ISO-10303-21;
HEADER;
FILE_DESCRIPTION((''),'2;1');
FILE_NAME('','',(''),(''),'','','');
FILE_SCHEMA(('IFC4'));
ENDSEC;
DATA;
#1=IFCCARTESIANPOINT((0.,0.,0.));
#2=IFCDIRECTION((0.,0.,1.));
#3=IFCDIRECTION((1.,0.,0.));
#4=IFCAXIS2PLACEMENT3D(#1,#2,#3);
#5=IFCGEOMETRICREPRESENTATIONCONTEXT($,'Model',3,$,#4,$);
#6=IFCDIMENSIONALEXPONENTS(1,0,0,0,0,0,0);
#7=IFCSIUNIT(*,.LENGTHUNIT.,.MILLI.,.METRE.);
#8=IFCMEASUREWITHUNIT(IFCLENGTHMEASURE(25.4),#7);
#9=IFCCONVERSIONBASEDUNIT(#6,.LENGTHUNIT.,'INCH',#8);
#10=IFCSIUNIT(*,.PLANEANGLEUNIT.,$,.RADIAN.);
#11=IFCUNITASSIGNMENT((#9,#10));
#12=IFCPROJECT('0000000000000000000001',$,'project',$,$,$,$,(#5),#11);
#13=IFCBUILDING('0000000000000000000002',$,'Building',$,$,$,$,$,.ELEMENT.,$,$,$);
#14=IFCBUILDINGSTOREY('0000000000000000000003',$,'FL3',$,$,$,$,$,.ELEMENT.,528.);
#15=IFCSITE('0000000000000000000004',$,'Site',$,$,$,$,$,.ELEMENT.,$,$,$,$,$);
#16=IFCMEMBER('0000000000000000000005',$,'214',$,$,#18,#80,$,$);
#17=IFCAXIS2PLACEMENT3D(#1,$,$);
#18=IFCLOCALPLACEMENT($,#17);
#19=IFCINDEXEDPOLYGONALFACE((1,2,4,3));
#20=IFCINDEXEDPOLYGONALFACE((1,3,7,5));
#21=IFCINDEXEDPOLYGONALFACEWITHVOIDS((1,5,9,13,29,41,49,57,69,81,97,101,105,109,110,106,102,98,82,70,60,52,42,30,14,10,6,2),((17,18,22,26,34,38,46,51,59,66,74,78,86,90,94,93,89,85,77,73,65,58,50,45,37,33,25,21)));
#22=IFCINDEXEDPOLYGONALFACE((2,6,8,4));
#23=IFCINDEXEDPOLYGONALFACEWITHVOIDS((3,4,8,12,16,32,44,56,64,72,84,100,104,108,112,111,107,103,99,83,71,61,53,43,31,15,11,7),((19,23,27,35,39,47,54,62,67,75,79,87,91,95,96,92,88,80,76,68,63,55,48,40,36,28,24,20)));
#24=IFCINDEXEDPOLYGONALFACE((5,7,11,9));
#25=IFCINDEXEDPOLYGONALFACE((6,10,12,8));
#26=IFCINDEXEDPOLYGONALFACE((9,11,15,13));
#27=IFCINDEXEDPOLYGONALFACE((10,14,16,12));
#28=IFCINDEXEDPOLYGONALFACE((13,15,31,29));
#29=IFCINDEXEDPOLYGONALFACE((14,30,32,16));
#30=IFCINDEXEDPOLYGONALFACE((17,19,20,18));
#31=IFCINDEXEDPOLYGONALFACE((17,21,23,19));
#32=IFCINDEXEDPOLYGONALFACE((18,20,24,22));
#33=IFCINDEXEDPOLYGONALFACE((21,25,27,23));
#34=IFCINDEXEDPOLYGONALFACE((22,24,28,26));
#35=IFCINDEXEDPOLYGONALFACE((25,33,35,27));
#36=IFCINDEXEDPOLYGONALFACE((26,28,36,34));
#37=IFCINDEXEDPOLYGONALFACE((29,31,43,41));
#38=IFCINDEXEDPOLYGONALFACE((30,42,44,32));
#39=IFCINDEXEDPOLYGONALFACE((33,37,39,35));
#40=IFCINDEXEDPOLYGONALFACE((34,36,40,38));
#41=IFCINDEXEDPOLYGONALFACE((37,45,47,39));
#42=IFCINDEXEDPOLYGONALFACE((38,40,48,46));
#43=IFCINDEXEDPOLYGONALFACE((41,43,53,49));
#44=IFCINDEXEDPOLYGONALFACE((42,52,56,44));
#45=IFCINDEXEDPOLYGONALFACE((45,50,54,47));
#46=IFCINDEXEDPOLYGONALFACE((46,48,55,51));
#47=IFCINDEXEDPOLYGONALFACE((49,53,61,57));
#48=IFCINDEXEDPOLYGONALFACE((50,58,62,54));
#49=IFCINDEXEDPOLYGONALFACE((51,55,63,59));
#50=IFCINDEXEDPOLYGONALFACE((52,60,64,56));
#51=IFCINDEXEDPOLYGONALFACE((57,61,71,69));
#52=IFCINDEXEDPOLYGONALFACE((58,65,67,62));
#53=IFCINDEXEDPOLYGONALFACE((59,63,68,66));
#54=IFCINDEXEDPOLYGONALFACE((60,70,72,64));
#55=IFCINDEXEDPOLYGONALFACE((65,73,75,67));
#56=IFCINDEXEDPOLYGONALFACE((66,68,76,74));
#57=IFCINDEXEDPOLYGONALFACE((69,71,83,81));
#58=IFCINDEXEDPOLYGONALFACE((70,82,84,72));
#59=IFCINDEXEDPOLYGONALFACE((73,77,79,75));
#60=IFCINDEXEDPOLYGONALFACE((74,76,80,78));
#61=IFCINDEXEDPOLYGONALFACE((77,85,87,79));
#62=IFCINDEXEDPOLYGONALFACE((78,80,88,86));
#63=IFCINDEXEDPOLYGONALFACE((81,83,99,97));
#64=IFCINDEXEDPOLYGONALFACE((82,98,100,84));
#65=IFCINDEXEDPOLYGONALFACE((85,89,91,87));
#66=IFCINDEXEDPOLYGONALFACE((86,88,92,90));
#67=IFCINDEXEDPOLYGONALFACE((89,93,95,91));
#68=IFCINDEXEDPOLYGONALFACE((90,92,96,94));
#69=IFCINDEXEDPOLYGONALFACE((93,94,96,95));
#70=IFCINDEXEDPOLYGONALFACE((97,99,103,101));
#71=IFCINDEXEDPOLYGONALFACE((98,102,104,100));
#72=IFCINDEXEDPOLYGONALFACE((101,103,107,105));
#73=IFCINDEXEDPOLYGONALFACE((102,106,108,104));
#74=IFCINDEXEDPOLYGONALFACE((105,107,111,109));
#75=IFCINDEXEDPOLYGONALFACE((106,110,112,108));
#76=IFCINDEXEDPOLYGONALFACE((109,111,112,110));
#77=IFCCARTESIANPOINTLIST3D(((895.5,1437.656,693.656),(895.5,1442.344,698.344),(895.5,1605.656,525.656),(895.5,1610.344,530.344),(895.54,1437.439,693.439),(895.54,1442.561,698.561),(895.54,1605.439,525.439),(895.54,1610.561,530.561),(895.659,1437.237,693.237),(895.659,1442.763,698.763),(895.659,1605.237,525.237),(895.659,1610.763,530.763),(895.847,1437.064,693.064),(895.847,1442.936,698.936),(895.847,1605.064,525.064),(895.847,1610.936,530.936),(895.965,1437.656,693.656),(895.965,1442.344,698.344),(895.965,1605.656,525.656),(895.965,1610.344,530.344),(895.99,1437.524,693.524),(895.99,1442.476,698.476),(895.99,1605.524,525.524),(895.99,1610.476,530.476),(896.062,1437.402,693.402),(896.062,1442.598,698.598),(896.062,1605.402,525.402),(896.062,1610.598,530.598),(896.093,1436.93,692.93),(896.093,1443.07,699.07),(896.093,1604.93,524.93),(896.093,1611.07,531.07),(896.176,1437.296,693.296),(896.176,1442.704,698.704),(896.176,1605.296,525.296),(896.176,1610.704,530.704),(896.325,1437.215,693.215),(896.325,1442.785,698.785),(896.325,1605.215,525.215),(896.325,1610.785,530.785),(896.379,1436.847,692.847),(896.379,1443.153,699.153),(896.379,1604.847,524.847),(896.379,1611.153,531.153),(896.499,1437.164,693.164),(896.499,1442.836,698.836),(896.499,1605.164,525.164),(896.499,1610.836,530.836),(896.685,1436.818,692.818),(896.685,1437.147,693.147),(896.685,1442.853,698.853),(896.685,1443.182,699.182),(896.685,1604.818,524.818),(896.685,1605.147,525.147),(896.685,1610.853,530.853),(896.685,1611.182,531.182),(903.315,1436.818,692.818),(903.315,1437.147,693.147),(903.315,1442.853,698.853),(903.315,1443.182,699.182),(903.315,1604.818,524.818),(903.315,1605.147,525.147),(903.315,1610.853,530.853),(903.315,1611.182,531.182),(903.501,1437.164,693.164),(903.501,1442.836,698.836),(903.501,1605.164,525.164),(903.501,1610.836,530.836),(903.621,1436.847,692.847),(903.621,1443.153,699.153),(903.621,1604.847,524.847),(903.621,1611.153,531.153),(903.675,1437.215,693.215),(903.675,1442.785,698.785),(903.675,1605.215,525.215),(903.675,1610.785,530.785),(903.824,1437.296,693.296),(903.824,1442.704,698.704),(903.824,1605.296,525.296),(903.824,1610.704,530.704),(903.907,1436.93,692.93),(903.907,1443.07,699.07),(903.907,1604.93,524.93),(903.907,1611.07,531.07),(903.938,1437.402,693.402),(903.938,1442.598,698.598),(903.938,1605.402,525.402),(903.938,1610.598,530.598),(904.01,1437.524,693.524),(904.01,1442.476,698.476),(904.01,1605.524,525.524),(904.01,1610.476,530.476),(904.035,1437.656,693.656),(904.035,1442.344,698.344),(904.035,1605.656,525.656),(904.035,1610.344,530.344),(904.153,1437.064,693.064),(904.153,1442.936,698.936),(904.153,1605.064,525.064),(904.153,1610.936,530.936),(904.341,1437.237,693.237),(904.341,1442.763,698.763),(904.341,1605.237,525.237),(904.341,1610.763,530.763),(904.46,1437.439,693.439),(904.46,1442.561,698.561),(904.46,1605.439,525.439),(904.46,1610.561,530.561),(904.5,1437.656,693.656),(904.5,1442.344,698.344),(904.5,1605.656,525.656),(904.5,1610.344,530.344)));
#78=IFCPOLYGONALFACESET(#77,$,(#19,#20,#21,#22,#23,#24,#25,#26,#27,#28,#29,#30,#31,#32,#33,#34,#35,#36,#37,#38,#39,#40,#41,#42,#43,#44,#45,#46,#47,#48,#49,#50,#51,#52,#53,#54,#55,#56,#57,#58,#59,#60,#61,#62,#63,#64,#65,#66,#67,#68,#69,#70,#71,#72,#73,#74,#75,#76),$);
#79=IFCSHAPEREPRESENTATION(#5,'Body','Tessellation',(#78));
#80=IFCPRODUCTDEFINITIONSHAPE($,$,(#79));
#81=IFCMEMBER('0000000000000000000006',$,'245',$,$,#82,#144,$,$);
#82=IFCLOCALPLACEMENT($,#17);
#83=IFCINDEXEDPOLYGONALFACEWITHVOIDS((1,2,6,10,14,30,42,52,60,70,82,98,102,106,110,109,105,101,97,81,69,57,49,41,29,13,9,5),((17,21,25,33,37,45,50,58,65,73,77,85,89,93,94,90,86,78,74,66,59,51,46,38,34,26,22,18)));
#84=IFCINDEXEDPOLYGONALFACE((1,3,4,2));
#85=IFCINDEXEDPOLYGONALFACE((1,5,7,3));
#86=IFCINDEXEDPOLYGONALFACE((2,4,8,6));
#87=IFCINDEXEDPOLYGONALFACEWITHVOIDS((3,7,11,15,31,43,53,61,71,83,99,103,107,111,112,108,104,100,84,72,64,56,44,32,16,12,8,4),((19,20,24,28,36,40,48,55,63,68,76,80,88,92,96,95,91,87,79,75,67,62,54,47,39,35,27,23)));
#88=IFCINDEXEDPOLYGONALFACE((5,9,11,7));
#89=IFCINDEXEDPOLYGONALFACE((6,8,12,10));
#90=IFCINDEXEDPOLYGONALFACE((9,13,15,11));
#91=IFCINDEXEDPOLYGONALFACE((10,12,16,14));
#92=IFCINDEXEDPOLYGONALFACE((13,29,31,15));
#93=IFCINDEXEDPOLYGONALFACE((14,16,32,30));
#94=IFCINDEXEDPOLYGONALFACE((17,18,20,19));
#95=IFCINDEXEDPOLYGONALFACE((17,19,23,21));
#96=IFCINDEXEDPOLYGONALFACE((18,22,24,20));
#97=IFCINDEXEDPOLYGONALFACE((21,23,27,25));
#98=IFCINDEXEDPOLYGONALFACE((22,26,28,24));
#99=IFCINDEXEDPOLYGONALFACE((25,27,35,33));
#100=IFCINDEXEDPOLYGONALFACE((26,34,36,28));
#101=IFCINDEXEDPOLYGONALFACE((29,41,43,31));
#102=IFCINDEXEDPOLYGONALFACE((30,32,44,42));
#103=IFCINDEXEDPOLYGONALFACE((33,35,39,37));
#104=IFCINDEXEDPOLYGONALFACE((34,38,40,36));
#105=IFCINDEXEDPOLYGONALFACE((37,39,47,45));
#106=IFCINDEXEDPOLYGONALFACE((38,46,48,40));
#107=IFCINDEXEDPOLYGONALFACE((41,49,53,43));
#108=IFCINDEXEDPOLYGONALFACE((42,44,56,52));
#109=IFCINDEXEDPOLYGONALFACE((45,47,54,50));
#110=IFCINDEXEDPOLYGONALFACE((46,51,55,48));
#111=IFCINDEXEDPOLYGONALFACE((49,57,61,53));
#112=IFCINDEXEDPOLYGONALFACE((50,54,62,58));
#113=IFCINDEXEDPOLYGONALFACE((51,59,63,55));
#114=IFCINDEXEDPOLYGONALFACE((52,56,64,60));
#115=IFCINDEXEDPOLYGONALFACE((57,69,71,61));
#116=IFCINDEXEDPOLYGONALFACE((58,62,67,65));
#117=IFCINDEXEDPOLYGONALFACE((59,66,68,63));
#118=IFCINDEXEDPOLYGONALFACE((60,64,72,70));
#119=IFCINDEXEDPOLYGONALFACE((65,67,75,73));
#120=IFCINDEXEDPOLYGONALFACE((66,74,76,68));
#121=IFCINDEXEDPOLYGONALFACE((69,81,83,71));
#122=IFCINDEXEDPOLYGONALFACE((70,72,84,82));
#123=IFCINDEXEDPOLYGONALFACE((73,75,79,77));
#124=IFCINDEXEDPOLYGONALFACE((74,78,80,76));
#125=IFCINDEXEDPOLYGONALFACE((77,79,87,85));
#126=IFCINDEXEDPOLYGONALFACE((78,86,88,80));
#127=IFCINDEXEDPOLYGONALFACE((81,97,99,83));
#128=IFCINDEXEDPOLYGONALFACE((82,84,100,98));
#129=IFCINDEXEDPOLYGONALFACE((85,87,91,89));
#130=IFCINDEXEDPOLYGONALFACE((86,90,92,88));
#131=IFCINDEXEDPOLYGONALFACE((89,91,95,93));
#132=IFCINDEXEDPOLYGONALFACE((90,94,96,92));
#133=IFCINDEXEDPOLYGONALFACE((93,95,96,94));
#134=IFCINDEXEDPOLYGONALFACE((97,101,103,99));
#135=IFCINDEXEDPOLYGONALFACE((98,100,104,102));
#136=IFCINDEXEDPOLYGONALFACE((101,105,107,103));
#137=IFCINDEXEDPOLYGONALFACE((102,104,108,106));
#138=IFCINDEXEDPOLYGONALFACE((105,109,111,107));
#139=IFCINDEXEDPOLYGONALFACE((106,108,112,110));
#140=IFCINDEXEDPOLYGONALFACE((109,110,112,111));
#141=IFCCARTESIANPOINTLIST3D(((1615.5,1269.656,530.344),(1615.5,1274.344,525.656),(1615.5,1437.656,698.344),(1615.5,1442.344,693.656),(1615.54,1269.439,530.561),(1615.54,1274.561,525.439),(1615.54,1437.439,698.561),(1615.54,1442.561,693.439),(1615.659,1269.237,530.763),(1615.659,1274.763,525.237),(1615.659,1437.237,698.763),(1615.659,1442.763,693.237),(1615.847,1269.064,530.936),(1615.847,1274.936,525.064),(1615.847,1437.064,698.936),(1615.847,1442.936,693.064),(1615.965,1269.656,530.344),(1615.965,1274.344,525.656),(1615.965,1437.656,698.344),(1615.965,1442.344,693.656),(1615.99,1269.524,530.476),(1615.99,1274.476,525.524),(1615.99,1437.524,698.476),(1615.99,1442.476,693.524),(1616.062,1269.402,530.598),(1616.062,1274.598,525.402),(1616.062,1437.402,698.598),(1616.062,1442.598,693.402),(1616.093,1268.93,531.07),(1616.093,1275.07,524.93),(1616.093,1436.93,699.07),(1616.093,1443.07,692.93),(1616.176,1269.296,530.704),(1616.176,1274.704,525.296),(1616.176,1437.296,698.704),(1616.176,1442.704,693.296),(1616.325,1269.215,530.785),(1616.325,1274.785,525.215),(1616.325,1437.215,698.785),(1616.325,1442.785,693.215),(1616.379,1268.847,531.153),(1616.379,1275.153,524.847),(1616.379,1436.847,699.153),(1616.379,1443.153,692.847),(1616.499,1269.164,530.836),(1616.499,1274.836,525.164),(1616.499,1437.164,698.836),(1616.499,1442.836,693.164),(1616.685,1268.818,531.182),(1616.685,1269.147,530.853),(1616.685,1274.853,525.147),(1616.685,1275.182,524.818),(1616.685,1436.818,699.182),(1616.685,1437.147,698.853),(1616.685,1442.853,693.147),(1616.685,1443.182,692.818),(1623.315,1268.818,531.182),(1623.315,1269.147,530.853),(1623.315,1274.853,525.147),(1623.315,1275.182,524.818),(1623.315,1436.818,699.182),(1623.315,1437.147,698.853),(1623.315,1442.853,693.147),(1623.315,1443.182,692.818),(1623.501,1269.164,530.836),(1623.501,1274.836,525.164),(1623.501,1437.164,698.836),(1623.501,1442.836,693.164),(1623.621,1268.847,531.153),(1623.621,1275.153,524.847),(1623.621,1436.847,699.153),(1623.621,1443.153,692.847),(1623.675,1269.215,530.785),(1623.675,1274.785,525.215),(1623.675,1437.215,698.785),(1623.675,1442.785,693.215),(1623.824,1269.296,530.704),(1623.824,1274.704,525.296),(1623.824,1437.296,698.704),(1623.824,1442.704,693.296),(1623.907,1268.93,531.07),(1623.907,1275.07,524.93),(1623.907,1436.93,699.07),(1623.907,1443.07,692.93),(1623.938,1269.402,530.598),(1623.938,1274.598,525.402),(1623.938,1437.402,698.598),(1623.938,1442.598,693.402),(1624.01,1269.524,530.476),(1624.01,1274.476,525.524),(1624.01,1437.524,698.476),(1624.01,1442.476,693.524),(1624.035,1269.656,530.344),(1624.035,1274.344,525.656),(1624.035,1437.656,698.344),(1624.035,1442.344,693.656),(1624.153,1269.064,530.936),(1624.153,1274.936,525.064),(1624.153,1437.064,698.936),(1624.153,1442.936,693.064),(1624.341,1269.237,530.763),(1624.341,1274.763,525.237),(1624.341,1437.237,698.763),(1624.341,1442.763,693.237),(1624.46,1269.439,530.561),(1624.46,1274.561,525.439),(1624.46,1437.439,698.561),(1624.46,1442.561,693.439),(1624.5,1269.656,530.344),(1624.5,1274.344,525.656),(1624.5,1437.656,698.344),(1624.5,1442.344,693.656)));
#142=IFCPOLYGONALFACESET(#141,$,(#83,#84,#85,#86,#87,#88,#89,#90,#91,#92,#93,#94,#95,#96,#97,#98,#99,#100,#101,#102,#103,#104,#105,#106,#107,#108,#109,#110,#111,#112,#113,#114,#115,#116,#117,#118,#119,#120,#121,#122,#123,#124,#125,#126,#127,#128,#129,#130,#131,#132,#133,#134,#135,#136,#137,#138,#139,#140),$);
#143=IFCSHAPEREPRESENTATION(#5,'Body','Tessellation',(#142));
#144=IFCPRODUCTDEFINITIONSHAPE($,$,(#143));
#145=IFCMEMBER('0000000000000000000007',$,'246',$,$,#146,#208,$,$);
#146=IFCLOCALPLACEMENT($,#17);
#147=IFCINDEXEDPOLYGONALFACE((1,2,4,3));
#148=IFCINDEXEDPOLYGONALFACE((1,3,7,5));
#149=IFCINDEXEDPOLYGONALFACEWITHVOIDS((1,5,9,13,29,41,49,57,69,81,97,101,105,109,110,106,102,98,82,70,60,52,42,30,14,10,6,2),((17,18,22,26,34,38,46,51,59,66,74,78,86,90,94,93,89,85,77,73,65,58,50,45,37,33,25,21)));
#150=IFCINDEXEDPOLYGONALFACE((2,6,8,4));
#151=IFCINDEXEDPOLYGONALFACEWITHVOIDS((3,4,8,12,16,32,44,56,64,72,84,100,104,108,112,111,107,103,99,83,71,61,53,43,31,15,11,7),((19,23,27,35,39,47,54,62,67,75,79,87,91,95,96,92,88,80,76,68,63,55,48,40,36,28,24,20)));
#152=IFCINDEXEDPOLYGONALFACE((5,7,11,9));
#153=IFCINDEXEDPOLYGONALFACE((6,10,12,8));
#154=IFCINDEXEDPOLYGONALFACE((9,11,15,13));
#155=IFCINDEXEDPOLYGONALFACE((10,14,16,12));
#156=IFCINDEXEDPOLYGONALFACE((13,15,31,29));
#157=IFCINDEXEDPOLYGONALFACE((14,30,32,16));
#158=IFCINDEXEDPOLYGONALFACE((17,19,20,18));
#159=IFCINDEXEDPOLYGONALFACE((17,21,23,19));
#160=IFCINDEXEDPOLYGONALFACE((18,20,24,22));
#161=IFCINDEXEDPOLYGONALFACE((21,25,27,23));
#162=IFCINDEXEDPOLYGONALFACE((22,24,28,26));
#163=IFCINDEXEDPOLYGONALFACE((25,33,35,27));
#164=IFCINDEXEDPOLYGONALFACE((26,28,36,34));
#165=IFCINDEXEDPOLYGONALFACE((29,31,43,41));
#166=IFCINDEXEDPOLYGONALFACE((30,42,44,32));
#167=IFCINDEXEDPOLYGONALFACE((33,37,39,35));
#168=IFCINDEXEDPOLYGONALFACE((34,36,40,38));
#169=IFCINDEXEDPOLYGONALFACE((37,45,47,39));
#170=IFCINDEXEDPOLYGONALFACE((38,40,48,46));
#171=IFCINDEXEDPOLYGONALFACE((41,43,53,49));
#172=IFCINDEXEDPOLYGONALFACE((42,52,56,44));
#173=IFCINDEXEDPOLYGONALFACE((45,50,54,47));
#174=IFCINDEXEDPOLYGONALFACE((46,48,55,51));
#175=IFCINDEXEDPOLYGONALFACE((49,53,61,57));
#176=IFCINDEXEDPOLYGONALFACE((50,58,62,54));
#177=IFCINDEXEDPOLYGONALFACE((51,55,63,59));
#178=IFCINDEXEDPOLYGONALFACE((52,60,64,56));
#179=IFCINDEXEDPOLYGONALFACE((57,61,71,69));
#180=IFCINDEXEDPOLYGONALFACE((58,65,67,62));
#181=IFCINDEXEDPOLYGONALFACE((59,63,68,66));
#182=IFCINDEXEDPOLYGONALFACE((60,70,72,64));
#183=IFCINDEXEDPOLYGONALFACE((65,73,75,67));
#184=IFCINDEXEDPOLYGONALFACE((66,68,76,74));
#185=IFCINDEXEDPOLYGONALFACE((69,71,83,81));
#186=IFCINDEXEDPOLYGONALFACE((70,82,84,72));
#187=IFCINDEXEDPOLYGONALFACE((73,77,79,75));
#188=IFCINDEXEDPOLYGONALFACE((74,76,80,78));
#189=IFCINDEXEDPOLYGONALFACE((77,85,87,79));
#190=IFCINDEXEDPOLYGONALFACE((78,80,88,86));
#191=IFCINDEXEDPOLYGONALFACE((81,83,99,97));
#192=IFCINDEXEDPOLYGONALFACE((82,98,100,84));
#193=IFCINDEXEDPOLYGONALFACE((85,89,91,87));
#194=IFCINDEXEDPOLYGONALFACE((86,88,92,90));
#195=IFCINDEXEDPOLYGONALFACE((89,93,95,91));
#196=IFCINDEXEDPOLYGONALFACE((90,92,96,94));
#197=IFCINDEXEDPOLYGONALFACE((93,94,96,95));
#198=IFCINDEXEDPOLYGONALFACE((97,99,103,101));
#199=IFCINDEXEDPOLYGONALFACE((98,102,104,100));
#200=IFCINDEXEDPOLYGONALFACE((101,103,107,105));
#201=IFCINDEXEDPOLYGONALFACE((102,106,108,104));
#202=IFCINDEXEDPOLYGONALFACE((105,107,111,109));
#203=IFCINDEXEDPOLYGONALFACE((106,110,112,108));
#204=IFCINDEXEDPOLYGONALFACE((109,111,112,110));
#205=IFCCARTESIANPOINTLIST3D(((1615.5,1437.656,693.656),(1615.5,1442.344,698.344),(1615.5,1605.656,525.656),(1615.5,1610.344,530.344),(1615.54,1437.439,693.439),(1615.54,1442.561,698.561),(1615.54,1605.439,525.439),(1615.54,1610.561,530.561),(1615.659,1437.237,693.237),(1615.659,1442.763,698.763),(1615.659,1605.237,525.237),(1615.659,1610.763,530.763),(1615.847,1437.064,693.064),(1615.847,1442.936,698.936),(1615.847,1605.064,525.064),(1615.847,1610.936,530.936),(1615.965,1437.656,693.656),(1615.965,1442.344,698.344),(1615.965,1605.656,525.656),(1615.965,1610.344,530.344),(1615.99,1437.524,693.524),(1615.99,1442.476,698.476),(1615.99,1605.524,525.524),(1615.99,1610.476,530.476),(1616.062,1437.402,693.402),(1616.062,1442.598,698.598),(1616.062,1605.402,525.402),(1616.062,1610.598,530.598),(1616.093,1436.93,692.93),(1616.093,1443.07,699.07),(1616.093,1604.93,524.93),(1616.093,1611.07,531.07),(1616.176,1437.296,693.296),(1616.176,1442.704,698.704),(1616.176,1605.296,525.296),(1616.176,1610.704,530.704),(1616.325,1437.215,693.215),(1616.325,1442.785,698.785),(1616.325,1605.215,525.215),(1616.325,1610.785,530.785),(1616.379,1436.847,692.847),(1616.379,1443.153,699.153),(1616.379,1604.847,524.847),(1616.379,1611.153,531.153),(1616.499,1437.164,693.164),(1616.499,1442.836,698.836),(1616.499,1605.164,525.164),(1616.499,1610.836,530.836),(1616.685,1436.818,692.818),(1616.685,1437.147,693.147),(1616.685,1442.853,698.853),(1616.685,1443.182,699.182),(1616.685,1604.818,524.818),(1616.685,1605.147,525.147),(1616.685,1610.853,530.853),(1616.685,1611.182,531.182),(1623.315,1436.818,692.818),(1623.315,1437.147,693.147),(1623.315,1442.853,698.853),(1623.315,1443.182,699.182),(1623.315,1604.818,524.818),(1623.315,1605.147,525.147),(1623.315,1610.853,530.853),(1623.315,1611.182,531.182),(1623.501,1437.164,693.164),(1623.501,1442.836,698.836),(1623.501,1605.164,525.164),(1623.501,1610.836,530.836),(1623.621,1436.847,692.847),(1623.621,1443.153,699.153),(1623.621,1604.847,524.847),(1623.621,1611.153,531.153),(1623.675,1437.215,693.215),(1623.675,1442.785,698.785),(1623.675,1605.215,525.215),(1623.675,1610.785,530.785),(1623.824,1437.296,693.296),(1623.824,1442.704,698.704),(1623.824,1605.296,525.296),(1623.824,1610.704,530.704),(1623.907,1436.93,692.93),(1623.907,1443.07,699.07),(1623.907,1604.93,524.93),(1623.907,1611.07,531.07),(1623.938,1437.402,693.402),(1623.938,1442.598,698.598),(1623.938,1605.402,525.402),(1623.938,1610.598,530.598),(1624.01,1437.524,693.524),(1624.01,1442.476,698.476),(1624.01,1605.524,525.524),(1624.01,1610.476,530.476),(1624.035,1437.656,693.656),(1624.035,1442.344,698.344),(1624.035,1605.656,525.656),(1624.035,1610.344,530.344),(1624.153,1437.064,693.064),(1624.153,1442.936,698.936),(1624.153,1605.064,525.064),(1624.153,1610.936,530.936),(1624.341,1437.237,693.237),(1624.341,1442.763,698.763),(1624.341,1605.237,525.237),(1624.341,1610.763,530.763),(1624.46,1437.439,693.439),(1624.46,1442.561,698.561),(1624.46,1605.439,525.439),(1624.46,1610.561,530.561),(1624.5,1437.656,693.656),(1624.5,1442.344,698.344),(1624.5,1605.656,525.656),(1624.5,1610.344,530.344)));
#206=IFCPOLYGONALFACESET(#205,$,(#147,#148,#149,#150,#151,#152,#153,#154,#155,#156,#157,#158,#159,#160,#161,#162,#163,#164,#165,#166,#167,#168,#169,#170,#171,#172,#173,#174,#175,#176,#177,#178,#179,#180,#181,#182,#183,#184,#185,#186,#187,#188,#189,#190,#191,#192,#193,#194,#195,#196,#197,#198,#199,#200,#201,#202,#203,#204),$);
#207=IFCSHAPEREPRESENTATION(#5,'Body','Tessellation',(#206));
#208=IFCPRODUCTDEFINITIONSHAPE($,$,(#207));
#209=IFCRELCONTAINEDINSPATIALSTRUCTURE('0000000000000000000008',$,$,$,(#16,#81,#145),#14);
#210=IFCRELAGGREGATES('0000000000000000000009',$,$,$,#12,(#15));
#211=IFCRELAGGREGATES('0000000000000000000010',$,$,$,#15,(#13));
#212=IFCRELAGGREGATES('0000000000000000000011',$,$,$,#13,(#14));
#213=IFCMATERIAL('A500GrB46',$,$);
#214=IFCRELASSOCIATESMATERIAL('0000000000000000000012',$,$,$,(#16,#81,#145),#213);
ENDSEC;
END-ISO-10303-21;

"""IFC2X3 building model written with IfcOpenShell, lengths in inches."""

from ifc_helpers import new_model, entity, si_unit, converted_unit, frame, origin_with_axes, origin_2d_with_axis, place, context, project, spatial, hollow_rectangle, extrude, material, element, save


model = new_model("IFC2X3")

# Units and contexts
model_context = context("Model", 3, world=origin_with_axes())
ifc_project = project(units=[converted_unit("LENGTHUNIT", "INCH", entity("IfcLengthMeasure", 25.4), si_unit("LENGTHUNIT", "METRE", prefix="MILLI"), dimensions=[1, 0, 0, 0, 0, 0, 0]), si_unit("PLANEANGLEUNIT", "RADIAN")], contexts=[model_context])

# Site, building, storey
site = spatial("IfcSite", under=ifc_project, Name="Site", CompositionType="ELEMENT")
building = spatial("IfcBuilding", under=site, Name="Building", CompositionType="ELEMENT")
storey = spatial("IfcBuildingStorey", under=building, Name="FL3", CompositionType="ELEMENT", Elevation=528.0)

# Members
ifc_material_1 = material(Name="A500GrB46")
for number, where, z_axis, x_axis, name in (
    (1, (900.0, 1608.0, 528.0), (0.0, -0.707107, 0.707107), (1.0, 0.0, 0.0), "214"),
    (2, (1620.0, 1272.0, 528.0), (0.0, 0.707107, 0.707107), (-1.0, 0.0, 0.0), "245"),
    (3, (1620.0, 1608.0, 528.0), (0.0, -0.707107, 0.707107), (1.0, 0.0, 0.0), "246"),
):
    element("IfcMember", number, at=place(None, frame(where, z_axis=z_axis, x_axis=x_axis)), inside=storey, material=ifc_material_1, Name=name, context=model_context, shape_type="SweptSolid", body=[
        extrude(hollow_rectangle(XDim=9.0, YDim=9.0, WallThickness=0.465, InnerFilletRadius=0.72, OuterFilletRadius=1.185, at=origin_2d_with_axis()), origin_with_axes(), (0.0, 0.0, 1.0), 237.588),
    ])

save(model, "model.ifc")
